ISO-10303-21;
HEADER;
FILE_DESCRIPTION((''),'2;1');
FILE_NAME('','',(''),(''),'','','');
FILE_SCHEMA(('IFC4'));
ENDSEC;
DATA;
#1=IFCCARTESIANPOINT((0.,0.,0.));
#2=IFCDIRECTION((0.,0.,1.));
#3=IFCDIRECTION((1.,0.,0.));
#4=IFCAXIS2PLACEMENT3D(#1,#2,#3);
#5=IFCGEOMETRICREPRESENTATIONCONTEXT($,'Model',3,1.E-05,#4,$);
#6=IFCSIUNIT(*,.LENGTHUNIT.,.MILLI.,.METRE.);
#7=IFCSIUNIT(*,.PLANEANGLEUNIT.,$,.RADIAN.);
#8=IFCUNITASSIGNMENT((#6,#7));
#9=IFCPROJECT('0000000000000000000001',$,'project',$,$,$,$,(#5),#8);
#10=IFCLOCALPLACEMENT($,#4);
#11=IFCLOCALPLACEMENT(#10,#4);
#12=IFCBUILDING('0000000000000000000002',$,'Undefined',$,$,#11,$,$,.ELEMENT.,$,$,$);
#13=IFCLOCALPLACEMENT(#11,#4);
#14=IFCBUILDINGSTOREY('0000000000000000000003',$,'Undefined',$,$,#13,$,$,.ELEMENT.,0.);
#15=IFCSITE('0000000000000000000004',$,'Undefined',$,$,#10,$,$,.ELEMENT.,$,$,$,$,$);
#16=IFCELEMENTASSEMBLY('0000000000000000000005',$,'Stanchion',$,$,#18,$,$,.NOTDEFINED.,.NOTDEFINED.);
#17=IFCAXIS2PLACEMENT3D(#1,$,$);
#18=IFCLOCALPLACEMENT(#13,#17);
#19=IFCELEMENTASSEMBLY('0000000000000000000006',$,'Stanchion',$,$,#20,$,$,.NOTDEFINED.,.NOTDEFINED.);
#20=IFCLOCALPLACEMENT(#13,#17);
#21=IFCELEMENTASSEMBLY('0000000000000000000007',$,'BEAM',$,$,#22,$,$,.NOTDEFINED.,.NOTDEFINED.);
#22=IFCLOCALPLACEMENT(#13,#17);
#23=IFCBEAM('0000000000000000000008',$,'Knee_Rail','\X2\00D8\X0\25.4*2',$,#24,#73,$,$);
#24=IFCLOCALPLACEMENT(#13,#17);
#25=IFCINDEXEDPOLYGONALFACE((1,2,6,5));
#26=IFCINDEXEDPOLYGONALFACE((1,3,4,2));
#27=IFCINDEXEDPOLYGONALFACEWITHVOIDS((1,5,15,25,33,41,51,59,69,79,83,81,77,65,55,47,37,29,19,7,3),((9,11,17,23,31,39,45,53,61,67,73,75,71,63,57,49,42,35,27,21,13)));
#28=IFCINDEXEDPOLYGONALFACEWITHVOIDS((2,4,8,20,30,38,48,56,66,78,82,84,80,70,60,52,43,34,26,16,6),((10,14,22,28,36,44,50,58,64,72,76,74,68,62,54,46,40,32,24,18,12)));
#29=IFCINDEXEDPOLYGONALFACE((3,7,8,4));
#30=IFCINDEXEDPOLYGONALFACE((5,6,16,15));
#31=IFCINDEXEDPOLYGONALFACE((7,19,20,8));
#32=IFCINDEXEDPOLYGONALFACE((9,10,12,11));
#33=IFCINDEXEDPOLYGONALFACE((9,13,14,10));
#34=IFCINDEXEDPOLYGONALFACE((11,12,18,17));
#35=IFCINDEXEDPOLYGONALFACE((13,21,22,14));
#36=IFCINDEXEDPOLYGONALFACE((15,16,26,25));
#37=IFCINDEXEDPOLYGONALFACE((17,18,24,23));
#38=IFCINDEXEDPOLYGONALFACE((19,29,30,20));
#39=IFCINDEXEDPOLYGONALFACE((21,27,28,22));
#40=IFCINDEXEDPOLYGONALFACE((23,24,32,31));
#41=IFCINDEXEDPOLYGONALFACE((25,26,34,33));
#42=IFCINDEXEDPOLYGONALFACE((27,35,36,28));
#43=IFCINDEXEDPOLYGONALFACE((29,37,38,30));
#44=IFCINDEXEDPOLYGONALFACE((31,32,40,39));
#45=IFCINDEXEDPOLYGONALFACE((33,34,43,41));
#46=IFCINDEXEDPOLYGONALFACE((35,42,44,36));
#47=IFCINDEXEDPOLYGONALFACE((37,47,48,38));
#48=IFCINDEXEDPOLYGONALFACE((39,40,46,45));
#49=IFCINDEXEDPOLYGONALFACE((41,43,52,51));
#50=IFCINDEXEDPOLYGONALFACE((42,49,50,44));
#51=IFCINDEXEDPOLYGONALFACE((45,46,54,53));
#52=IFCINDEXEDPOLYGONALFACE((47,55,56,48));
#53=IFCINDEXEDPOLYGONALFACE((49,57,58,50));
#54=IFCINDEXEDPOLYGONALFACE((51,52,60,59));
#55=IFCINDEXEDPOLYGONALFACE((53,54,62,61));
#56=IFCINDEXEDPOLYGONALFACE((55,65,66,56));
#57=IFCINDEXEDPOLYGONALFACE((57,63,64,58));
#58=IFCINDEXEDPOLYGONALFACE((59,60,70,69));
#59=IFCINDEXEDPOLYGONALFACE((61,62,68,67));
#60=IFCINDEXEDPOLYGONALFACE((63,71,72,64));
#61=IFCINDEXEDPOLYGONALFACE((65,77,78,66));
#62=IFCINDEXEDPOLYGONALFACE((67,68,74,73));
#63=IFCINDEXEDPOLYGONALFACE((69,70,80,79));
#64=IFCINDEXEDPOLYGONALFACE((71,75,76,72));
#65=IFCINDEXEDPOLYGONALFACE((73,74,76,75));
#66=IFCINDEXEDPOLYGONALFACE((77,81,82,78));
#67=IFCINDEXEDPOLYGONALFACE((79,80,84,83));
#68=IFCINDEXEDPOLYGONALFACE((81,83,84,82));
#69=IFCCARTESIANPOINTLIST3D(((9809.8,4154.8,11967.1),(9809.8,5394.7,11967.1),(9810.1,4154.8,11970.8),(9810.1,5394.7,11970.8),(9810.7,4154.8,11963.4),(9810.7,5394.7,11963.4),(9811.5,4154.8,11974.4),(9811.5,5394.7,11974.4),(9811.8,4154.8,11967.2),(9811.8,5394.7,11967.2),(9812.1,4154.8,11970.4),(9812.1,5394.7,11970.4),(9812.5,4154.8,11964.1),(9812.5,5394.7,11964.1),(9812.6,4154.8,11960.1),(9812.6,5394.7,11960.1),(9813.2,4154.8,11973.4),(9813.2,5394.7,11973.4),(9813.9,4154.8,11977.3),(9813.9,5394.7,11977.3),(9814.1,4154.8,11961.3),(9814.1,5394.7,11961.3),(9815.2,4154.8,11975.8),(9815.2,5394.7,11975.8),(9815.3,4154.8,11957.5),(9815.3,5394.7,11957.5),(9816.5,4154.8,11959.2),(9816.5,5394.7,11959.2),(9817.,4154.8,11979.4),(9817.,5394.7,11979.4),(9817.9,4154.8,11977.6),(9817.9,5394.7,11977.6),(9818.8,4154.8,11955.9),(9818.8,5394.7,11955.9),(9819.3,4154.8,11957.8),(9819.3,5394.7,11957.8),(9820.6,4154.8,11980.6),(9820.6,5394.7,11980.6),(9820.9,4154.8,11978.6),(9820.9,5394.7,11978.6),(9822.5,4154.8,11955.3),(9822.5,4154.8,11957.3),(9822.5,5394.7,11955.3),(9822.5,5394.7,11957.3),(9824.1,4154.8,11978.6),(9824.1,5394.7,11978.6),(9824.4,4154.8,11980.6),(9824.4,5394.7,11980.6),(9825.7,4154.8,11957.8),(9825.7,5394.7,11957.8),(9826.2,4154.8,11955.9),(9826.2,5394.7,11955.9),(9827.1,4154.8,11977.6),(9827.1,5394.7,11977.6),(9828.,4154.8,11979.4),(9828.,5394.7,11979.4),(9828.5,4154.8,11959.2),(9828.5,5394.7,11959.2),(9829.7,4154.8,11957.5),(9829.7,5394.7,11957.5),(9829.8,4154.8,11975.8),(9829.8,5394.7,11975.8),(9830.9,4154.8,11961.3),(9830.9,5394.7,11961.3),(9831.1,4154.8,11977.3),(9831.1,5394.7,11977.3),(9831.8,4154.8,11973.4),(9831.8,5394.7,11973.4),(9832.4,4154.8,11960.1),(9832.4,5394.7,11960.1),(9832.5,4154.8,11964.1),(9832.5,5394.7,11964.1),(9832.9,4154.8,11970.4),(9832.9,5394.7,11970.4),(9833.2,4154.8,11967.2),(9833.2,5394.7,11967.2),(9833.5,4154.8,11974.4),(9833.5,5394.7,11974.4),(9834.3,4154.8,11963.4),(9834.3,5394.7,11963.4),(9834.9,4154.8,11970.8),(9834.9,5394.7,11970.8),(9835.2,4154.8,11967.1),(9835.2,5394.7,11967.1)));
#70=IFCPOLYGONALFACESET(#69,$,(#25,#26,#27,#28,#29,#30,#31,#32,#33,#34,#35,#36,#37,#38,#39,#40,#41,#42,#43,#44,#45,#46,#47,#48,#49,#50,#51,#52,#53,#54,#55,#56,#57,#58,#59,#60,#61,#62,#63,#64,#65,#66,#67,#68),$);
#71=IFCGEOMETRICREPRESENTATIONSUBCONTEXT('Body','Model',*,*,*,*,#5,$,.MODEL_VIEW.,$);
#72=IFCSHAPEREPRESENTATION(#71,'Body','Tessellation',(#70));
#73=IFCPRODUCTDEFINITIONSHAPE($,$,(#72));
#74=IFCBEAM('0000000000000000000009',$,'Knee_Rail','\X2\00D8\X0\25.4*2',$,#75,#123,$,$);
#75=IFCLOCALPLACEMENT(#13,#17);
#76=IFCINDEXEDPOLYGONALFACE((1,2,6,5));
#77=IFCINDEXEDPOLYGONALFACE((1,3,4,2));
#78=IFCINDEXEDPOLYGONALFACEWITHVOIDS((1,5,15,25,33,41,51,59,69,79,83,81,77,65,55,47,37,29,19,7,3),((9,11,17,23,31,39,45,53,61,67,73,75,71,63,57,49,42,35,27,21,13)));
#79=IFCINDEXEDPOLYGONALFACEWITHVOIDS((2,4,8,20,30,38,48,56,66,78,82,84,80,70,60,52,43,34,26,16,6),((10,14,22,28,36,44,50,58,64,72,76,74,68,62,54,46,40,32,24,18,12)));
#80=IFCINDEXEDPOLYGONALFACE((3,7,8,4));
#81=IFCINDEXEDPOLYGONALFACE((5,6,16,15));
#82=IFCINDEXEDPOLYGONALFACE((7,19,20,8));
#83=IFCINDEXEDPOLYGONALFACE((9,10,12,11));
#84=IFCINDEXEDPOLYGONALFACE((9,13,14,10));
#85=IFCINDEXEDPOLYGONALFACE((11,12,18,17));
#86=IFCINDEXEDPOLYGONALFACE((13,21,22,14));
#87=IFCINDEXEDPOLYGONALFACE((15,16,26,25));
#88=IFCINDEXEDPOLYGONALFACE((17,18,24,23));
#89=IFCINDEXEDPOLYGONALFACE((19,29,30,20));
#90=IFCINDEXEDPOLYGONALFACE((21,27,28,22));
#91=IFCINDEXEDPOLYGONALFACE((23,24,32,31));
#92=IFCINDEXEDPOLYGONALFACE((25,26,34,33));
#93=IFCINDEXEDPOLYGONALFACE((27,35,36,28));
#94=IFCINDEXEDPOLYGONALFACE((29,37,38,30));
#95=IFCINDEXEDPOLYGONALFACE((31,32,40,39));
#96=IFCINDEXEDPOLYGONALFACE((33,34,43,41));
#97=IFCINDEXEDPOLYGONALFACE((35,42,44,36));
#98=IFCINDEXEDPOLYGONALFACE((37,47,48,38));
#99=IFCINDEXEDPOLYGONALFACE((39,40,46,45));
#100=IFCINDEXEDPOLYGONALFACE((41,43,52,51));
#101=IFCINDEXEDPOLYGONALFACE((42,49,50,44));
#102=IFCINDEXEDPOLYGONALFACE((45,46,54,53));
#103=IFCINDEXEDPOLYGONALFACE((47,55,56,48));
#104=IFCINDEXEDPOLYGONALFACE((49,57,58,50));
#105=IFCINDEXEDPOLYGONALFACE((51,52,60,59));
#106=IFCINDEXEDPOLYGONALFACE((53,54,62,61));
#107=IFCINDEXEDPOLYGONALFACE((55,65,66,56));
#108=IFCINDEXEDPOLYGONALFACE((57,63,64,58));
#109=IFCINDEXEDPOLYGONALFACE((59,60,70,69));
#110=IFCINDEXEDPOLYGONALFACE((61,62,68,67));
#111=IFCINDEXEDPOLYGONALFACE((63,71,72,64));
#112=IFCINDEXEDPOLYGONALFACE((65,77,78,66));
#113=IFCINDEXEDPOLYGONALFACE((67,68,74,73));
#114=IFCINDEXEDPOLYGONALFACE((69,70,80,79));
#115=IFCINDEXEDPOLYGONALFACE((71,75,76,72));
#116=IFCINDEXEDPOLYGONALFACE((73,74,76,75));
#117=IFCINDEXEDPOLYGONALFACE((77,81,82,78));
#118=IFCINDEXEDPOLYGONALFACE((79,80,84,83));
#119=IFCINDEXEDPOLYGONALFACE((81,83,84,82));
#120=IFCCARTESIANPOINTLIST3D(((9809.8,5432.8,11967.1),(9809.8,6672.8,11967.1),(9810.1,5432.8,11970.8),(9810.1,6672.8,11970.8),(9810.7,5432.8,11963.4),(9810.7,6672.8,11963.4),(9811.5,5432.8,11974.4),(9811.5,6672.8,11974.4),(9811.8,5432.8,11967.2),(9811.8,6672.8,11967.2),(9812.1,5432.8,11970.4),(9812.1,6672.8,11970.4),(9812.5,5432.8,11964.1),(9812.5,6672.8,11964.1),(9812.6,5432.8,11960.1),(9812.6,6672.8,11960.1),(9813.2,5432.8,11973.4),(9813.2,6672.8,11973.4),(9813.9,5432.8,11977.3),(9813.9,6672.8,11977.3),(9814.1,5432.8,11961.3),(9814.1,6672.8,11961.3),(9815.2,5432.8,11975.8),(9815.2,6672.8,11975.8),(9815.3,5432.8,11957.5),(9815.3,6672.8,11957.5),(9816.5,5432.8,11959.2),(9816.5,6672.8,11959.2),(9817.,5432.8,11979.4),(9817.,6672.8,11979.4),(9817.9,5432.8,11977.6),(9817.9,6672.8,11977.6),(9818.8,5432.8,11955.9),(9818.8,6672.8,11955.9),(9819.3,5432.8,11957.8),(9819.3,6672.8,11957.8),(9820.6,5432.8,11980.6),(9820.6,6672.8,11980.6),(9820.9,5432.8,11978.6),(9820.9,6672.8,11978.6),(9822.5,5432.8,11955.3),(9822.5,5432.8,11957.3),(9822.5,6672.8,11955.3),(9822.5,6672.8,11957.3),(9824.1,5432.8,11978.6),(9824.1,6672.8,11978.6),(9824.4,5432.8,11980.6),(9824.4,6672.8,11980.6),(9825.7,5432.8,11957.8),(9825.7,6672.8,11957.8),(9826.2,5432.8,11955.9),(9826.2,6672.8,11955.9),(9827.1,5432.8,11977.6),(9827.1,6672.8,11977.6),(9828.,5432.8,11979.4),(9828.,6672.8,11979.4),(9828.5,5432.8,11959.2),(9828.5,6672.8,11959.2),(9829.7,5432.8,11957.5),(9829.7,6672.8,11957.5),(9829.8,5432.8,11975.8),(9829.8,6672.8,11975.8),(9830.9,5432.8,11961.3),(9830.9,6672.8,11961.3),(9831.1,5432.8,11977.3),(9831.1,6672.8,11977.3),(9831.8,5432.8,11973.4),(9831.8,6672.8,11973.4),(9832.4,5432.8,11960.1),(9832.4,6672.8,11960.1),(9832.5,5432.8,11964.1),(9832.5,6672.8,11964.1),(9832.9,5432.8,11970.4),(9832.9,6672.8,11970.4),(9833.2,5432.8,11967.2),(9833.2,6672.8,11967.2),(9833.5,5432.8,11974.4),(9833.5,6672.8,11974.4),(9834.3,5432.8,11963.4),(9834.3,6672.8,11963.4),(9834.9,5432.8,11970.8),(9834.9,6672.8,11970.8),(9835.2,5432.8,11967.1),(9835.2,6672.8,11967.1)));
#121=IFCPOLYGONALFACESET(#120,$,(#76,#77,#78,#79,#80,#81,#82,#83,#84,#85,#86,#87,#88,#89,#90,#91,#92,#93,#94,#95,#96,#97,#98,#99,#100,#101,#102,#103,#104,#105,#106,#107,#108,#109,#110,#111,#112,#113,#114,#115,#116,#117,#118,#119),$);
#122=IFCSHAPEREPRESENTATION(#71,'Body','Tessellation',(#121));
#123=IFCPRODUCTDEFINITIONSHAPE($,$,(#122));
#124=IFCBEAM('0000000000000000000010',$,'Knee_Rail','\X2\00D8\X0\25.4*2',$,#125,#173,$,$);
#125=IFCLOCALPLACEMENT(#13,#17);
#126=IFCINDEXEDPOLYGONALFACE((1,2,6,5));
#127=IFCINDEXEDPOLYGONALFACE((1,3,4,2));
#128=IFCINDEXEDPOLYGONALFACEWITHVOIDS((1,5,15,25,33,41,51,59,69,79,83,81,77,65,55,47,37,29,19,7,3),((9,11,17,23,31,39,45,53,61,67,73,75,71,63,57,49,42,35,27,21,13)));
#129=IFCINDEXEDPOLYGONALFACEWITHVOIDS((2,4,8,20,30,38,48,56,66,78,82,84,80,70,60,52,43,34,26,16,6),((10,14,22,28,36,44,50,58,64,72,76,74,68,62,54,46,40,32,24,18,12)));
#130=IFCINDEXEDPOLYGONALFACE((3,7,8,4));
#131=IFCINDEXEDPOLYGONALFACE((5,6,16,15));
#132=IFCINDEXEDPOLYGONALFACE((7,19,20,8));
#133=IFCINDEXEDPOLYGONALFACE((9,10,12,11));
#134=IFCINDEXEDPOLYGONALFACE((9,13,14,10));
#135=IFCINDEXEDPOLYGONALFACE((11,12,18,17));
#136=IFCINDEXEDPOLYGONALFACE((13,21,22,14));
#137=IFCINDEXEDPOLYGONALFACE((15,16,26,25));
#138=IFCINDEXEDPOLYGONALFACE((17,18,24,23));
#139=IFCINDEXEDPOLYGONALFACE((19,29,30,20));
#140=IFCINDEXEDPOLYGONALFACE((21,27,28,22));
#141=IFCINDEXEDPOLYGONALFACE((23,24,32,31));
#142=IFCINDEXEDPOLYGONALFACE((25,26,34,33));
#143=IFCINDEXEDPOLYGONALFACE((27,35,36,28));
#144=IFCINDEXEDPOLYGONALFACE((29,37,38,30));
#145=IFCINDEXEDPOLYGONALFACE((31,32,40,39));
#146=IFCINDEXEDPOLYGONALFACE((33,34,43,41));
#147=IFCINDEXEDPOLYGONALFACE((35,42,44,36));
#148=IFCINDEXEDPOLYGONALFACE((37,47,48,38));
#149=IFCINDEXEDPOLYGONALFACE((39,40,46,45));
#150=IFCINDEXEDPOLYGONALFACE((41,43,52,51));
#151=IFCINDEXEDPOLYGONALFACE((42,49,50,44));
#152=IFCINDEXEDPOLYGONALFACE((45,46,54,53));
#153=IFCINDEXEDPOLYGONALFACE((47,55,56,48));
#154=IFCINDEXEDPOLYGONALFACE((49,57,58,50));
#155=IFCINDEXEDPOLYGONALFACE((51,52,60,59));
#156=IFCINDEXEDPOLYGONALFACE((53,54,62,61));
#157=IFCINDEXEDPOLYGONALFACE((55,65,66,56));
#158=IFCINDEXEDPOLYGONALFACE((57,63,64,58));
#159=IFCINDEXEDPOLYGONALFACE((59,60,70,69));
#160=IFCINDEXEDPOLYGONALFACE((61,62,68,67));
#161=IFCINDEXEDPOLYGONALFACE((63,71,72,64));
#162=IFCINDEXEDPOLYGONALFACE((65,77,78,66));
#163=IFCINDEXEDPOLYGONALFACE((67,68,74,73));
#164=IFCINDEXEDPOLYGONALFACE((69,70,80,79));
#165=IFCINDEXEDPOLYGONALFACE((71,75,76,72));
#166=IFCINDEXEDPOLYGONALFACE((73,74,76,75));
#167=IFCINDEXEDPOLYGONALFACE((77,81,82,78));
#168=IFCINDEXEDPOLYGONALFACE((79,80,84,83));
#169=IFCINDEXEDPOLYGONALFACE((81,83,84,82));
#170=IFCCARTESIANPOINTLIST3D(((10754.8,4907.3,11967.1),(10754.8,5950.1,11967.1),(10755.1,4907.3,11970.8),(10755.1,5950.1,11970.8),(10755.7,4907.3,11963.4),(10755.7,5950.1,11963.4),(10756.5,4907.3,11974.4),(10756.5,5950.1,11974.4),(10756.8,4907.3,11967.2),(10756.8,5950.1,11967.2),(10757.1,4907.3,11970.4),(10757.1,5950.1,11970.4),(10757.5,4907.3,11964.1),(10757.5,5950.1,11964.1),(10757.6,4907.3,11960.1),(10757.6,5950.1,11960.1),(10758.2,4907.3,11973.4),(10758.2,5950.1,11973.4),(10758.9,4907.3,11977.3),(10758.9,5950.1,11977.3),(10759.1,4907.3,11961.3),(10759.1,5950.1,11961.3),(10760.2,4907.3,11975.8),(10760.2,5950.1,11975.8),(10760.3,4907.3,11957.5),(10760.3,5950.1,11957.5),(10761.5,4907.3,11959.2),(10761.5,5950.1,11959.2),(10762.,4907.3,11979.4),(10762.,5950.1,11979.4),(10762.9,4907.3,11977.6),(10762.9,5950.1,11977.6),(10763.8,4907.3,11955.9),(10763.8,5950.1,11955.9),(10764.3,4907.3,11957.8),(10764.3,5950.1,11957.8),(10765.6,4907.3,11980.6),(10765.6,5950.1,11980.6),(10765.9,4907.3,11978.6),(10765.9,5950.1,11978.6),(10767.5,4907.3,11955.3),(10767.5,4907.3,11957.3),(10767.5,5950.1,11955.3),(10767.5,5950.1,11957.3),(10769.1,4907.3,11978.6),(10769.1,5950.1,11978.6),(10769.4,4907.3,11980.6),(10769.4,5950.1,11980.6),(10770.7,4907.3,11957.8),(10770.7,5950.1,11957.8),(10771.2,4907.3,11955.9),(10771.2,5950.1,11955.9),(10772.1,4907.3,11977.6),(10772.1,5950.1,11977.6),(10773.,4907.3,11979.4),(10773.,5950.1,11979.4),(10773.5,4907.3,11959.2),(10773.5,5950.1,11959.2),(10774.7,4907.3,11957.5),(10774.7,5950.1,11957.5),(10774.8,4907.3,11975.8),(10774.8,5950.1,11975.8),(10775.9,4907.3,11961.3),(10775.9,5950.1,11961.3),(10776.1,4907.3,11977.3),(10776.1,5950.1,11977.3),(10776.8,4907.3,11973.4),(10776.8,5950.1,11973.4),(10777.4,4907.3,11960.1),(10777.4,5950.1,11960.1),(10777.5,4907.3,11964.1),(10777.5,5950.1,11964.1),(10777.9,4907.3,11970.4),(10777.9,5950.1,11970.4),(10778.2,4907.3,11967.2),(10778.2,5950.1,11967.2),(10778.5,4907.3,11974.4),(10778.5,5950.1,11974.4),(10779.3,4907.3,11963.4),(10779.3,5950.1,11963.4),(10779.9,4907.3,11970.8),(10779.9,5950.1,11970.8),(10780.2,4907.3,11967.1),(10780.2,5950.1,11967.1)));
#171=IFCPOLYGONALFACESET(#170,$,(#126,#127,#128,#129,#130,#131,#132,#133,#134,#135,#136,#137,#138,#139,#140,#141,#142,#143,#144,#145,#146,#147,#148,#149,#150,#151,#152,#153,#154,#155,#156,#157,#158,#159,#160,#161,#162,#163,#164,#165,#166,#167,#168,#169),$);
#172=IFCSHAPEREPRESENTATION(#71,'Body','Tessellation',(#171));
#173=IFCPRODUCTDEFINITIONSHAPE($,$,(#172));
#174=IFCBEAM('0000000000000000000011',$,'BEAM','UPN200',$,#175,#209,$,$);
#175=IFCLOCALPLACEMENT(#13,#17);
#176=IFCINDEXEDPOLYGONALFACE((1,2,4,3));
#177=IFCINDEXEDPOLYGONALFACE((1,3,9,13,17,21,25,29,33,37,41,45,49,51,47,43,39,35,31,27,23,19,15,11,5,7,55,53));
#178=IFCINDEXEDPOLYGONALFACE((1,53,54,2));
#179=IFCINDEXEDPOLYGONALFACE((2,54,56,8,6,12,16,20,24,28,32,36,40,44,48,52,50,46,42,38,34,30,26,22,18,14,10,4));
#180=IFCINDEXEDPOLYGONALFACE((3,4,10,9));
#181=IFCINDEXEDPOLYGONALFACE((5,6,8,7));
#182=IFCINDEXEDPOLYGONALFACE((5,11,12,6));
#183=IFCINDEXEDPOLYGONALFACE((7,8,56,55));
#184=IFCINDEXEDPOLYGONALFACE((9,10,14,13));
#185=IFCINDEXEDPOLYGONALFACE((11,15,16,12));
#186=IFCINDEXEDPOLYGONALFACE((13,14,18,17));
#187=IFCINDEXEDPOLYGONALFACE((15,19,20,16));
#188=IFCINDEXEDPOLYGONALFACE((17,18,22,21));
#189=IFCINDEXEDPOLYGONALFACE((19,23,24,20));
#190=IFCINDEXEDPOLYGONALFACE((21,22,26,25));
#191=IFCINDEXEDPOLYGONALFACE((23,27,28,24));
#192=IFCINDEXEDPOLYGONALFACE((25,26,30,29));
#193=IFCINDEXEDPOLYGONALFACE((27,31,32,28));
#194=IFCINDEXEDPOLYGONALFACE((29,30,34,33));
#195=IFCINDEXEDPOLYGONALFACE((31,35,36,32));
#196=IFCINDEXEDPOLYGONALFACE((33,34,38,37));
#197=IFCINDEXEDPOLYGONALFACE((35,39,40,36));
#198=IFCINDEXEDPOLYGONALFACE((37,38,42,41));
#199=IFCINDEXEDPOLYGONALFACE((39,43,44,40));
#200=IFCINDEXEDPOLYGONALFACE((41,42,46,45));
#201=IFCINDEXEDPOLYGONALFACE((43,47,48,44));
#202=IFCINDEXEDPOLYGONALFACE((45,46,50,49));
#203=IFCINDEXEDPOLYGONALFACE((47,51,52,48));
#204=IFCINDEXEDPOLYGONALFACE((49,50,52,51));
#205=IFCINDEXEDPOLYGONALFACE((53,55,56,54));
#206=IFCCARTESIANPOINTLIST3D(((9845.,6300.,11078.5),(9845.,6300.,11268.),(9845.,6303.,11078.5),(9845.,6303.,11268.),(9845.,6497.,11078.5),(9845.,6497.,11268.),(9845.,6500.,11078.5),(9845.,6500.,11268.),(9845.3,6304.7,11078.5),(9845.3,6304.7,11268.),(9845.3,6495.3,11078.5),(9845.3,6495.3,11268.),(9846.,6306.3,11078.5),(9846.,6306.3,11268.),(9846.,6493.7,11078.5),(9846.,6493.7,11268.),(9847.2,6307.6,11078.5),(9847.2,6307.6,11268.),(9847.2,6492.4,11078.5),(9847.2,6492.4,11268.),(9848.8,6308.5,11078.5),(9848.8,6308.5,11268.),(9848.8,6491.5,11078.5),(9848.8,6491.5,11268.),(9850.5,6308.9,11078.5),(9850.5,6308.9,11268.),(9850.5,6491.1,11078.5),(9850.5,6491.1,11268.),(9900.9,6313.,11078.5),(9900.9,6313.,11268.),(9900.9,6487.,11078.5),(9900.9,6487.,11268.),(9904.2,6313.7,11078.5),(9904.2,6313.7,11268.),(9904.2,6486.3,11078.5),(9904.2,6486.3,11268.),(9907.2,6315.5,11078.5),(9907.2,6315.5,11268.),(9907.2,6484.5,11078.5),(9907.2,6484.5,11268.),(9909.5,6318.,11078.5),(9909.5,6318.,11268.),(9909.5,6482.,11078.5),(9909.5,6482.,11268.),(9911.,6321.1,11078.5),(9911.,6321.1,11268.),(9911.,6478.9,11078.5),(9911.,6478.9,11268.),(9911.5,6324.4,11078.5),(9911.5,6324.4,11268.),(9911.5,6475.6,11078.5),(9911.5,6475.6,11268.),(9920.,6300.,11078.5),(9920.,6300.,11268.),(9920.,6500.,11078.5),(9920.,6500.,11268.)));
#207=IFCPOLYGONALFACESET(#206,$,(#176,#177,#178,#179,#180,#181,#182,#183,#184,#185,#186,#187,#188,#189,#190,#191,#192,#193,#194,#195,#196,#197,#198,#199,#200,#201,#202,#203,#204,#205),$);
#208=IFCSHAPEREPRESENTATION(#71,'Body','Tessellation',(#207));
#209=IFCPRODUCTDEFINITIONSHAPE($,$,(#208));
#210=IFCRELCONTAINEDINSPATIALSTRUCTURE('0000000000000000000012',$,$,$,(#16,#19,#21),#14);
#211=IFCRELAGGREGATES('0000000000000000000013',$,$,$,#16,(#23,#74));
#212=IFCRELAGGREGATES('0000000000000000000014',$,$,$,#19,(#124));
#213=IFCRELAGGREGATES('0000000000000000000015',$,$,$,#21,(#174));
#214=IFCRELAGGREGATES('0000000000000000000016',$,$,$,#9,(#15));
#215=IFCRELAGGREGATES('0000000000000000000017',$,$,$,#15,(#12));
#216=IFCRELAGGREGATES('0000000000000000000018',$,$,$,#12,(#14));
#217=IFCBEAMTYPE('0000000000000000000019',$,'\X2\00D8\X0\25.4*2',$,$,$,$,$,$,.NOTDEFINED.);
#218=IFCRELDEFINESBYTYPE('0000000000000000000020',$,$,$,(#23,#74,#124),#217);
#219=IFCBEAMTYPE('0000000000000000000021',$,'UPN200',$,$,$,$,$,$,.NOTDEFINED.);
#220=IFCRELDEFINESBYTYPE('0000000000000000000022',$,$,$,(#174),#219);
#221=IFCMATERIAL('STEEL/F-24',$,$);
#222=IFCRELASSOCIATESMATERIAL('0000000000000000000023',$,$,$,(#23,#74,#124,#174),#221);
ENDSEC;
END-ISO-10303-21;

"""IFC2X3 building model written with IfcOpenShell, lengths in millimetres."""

from ifc_helpers import new_model, si_unit, frame, origin_with_axes, origin_2d_with_axis, place, context, subcontext, project, spatial, hollow_circle, u_section, extrude, material, type_object, element, aggregate, save


model = new_model("IFC2X3")

# Units and contexts
model_context = context("Model", 3, precision=1e-05, world=origin_with_axes())
body_context = subcontext(model_context, "Body", "Model", "MODEL_VIEW")
ifc_project = project(units=[si_unit("LENGTHUNIT", "METRE", prefix="MILLI"), si_unit("PLANEANGLEUNIT", "RADIAN")], contexts=[model_context])

# Site, building, storey
site_placement = place(None, origin_with_axes())
site = spatial("IfcSite", under=ifc_project, at=site_placement, Name="Undefined", CompositionType="ELEMENT")
building_placement = place(site_placement, origin_with_axes())
building = spatial("IfcBuilding", under=site, at=building_placement, Name="Undefined", CompositionType="ELEMENT")
storey_placement = place(building_placement, origin_with_axes())
storey = spatial("IfcBuildingStorey", under=building, at=storey_placement, Name="Undefined", CompositionType="ELEMENT", Elevation=0.0)

# Element assemblies
assembly_1_placement = place(storey_placement, origin_with_axes())
assembly_1 = element("IfcElementAssembly", 1, at=assembly_1_placement, inside=storey, Name="Stanchion", AssemblyPlace="NOTDEFINED", PredefinedType="NOTDEFINED")
ifc_material_1 = material(Name="STEEL/F-24")
assembly_2_placement = place(storey_placement, origin_with_axes())
assembly_2 = element("IfcElementAssembly", 2, at=assembly_2_placement, inside=storey, Name="Stanchion", AssemblyPlace="NOTDEFINED", PredefinedType="NOTDEFINED")

# Element assembly
assembly_3_placement = place(storey_placement, origin_with_axes())
assembly_3 = element("IfcElementAssembly", 3, at=assembly_3_placement, inside=storey, Name="BEAM", AssemblyPlace="NOTDEFINED", PredefinedType="NOTDEFINED")

# Beams
beam_type_1 = type_object("IfcBeamType", Name="Ø25.4*2", PredefinedType="NOTDEFINED")
beam_1_placement = place(assembly_1_placement, frame((9822.5, 5394.7, 11968.0), z_axis=(-1.0, 0.0, 0.0), x_axis=(0.0, -1.0, 0.0)))
beam_1 = element("IfcBeam", 4, at=beam_1_placement, type_object=beam_type_1, material=ifc_material_1, Name="Knee_Rail", Description="Ø25.4*2", context=body_context, shape_type="SweptSolid", body=[
    extrude(hollow_circle(Radius=12.7, WallThickness=2.0, at=origin_2d_with_axis()), frame((1239.9, 0.0, 0.0), z_axis=(-1.0, 0.0, 0.0), x_axis=(0.0, -1.0, 0.0)), (0.0, 0.0, 1.0), 1239.9),
])
beam_2_placement = place(assembly_1_placement, frame((9822.5, 6672.8, 11968.0), z_axis=(-1.0, 0.0, 0.0), x_axis=(0.0, -1.0, 0.0)))
beam_2 = element("IfcBeam", 5, at=beam_2_placement, type_object=beam_type_1, material=ifc_material_1, Name="Knee_Rail", Description="Ø25.4*2", context=body_context, shape_type="SweptSolid", body=[
    extrude(hollow_circle(Radius=12.7, WallThickness=2.0, at=origin_2d_with_axis()), frame((1239.9, 0.0, 0.0), z_axis=(-1.0, 0.0, 0.0), x_axis=(0.0, -1.0, 0.0)), (0.0, 0.0, 1.0), 1239.9),
])
beam_3_placement = place(assembly_2_placement, frame((10767.5, 5950.1, 11968.0), z_axis=(-1.0, 0.0, 0.0), x_axis=(0.0, -1.0, 0.0)))
beam_3 = element("IfcBeam", 6, at=beam_3_placement, type_object=beam_type_1, material=ifc_material_1, Name="Knee_Rail", Description="Ø25.4*2", context=body_context, shape_type="SweptSolid", body=[
    extrude(hollow_circle(Radius=12.7, WallThickness=2.0, at=origin_2d_with_axis()), frame((1042.8, 0.0, 0.0), z_axis=(-1.0, 0.0, 0.0), x_axis=(0.0, -1.0, 0.0)), (0.0, 0.0, 1.0), 1042.8),
])
beam_type_2 = type_object("IfcBeamType", Name="UPN200", PredefinedType="NOTDEFINED")
beam_4_placement = place(assembly_3_placement, frame((9882.5, 6400.0, 11268.0), z_axis=(0.0, -1.0, 0.0), x_axis=(0.0, 0.0, -1.0)))
beam_4 = element("IfcBeam", 7, at=beam_4_placement, type_object=beam_type_2, material=ifc_material_1, Name="BEAM", Description="UPN200", context=body_context, shape_type="SweptSolid", body=[
    extrude(u_section(Depth=200.0, FlangeWidth=75.0, WebThickness=8.5, FlangeThickness=11.5, FilletRadius=11.5, EdgeRadius=6.0, FlangeSlope=0.07983, at=origin_2d_with_axis()), frame((189.5, 0.0, 0.0), z_axis=(-1.0, 0.0, 0.0), x_axis=(0.0, -1.0, 0.0)), (0.0, 0.0, 1.0), 189.5),
])

aggregate(assembly_1, [beam_1, beam_2])
aggregate(assembly_2, [beam_3])

aggregate(assembly_3, [beam_4])

save(model, "model.ifc")
